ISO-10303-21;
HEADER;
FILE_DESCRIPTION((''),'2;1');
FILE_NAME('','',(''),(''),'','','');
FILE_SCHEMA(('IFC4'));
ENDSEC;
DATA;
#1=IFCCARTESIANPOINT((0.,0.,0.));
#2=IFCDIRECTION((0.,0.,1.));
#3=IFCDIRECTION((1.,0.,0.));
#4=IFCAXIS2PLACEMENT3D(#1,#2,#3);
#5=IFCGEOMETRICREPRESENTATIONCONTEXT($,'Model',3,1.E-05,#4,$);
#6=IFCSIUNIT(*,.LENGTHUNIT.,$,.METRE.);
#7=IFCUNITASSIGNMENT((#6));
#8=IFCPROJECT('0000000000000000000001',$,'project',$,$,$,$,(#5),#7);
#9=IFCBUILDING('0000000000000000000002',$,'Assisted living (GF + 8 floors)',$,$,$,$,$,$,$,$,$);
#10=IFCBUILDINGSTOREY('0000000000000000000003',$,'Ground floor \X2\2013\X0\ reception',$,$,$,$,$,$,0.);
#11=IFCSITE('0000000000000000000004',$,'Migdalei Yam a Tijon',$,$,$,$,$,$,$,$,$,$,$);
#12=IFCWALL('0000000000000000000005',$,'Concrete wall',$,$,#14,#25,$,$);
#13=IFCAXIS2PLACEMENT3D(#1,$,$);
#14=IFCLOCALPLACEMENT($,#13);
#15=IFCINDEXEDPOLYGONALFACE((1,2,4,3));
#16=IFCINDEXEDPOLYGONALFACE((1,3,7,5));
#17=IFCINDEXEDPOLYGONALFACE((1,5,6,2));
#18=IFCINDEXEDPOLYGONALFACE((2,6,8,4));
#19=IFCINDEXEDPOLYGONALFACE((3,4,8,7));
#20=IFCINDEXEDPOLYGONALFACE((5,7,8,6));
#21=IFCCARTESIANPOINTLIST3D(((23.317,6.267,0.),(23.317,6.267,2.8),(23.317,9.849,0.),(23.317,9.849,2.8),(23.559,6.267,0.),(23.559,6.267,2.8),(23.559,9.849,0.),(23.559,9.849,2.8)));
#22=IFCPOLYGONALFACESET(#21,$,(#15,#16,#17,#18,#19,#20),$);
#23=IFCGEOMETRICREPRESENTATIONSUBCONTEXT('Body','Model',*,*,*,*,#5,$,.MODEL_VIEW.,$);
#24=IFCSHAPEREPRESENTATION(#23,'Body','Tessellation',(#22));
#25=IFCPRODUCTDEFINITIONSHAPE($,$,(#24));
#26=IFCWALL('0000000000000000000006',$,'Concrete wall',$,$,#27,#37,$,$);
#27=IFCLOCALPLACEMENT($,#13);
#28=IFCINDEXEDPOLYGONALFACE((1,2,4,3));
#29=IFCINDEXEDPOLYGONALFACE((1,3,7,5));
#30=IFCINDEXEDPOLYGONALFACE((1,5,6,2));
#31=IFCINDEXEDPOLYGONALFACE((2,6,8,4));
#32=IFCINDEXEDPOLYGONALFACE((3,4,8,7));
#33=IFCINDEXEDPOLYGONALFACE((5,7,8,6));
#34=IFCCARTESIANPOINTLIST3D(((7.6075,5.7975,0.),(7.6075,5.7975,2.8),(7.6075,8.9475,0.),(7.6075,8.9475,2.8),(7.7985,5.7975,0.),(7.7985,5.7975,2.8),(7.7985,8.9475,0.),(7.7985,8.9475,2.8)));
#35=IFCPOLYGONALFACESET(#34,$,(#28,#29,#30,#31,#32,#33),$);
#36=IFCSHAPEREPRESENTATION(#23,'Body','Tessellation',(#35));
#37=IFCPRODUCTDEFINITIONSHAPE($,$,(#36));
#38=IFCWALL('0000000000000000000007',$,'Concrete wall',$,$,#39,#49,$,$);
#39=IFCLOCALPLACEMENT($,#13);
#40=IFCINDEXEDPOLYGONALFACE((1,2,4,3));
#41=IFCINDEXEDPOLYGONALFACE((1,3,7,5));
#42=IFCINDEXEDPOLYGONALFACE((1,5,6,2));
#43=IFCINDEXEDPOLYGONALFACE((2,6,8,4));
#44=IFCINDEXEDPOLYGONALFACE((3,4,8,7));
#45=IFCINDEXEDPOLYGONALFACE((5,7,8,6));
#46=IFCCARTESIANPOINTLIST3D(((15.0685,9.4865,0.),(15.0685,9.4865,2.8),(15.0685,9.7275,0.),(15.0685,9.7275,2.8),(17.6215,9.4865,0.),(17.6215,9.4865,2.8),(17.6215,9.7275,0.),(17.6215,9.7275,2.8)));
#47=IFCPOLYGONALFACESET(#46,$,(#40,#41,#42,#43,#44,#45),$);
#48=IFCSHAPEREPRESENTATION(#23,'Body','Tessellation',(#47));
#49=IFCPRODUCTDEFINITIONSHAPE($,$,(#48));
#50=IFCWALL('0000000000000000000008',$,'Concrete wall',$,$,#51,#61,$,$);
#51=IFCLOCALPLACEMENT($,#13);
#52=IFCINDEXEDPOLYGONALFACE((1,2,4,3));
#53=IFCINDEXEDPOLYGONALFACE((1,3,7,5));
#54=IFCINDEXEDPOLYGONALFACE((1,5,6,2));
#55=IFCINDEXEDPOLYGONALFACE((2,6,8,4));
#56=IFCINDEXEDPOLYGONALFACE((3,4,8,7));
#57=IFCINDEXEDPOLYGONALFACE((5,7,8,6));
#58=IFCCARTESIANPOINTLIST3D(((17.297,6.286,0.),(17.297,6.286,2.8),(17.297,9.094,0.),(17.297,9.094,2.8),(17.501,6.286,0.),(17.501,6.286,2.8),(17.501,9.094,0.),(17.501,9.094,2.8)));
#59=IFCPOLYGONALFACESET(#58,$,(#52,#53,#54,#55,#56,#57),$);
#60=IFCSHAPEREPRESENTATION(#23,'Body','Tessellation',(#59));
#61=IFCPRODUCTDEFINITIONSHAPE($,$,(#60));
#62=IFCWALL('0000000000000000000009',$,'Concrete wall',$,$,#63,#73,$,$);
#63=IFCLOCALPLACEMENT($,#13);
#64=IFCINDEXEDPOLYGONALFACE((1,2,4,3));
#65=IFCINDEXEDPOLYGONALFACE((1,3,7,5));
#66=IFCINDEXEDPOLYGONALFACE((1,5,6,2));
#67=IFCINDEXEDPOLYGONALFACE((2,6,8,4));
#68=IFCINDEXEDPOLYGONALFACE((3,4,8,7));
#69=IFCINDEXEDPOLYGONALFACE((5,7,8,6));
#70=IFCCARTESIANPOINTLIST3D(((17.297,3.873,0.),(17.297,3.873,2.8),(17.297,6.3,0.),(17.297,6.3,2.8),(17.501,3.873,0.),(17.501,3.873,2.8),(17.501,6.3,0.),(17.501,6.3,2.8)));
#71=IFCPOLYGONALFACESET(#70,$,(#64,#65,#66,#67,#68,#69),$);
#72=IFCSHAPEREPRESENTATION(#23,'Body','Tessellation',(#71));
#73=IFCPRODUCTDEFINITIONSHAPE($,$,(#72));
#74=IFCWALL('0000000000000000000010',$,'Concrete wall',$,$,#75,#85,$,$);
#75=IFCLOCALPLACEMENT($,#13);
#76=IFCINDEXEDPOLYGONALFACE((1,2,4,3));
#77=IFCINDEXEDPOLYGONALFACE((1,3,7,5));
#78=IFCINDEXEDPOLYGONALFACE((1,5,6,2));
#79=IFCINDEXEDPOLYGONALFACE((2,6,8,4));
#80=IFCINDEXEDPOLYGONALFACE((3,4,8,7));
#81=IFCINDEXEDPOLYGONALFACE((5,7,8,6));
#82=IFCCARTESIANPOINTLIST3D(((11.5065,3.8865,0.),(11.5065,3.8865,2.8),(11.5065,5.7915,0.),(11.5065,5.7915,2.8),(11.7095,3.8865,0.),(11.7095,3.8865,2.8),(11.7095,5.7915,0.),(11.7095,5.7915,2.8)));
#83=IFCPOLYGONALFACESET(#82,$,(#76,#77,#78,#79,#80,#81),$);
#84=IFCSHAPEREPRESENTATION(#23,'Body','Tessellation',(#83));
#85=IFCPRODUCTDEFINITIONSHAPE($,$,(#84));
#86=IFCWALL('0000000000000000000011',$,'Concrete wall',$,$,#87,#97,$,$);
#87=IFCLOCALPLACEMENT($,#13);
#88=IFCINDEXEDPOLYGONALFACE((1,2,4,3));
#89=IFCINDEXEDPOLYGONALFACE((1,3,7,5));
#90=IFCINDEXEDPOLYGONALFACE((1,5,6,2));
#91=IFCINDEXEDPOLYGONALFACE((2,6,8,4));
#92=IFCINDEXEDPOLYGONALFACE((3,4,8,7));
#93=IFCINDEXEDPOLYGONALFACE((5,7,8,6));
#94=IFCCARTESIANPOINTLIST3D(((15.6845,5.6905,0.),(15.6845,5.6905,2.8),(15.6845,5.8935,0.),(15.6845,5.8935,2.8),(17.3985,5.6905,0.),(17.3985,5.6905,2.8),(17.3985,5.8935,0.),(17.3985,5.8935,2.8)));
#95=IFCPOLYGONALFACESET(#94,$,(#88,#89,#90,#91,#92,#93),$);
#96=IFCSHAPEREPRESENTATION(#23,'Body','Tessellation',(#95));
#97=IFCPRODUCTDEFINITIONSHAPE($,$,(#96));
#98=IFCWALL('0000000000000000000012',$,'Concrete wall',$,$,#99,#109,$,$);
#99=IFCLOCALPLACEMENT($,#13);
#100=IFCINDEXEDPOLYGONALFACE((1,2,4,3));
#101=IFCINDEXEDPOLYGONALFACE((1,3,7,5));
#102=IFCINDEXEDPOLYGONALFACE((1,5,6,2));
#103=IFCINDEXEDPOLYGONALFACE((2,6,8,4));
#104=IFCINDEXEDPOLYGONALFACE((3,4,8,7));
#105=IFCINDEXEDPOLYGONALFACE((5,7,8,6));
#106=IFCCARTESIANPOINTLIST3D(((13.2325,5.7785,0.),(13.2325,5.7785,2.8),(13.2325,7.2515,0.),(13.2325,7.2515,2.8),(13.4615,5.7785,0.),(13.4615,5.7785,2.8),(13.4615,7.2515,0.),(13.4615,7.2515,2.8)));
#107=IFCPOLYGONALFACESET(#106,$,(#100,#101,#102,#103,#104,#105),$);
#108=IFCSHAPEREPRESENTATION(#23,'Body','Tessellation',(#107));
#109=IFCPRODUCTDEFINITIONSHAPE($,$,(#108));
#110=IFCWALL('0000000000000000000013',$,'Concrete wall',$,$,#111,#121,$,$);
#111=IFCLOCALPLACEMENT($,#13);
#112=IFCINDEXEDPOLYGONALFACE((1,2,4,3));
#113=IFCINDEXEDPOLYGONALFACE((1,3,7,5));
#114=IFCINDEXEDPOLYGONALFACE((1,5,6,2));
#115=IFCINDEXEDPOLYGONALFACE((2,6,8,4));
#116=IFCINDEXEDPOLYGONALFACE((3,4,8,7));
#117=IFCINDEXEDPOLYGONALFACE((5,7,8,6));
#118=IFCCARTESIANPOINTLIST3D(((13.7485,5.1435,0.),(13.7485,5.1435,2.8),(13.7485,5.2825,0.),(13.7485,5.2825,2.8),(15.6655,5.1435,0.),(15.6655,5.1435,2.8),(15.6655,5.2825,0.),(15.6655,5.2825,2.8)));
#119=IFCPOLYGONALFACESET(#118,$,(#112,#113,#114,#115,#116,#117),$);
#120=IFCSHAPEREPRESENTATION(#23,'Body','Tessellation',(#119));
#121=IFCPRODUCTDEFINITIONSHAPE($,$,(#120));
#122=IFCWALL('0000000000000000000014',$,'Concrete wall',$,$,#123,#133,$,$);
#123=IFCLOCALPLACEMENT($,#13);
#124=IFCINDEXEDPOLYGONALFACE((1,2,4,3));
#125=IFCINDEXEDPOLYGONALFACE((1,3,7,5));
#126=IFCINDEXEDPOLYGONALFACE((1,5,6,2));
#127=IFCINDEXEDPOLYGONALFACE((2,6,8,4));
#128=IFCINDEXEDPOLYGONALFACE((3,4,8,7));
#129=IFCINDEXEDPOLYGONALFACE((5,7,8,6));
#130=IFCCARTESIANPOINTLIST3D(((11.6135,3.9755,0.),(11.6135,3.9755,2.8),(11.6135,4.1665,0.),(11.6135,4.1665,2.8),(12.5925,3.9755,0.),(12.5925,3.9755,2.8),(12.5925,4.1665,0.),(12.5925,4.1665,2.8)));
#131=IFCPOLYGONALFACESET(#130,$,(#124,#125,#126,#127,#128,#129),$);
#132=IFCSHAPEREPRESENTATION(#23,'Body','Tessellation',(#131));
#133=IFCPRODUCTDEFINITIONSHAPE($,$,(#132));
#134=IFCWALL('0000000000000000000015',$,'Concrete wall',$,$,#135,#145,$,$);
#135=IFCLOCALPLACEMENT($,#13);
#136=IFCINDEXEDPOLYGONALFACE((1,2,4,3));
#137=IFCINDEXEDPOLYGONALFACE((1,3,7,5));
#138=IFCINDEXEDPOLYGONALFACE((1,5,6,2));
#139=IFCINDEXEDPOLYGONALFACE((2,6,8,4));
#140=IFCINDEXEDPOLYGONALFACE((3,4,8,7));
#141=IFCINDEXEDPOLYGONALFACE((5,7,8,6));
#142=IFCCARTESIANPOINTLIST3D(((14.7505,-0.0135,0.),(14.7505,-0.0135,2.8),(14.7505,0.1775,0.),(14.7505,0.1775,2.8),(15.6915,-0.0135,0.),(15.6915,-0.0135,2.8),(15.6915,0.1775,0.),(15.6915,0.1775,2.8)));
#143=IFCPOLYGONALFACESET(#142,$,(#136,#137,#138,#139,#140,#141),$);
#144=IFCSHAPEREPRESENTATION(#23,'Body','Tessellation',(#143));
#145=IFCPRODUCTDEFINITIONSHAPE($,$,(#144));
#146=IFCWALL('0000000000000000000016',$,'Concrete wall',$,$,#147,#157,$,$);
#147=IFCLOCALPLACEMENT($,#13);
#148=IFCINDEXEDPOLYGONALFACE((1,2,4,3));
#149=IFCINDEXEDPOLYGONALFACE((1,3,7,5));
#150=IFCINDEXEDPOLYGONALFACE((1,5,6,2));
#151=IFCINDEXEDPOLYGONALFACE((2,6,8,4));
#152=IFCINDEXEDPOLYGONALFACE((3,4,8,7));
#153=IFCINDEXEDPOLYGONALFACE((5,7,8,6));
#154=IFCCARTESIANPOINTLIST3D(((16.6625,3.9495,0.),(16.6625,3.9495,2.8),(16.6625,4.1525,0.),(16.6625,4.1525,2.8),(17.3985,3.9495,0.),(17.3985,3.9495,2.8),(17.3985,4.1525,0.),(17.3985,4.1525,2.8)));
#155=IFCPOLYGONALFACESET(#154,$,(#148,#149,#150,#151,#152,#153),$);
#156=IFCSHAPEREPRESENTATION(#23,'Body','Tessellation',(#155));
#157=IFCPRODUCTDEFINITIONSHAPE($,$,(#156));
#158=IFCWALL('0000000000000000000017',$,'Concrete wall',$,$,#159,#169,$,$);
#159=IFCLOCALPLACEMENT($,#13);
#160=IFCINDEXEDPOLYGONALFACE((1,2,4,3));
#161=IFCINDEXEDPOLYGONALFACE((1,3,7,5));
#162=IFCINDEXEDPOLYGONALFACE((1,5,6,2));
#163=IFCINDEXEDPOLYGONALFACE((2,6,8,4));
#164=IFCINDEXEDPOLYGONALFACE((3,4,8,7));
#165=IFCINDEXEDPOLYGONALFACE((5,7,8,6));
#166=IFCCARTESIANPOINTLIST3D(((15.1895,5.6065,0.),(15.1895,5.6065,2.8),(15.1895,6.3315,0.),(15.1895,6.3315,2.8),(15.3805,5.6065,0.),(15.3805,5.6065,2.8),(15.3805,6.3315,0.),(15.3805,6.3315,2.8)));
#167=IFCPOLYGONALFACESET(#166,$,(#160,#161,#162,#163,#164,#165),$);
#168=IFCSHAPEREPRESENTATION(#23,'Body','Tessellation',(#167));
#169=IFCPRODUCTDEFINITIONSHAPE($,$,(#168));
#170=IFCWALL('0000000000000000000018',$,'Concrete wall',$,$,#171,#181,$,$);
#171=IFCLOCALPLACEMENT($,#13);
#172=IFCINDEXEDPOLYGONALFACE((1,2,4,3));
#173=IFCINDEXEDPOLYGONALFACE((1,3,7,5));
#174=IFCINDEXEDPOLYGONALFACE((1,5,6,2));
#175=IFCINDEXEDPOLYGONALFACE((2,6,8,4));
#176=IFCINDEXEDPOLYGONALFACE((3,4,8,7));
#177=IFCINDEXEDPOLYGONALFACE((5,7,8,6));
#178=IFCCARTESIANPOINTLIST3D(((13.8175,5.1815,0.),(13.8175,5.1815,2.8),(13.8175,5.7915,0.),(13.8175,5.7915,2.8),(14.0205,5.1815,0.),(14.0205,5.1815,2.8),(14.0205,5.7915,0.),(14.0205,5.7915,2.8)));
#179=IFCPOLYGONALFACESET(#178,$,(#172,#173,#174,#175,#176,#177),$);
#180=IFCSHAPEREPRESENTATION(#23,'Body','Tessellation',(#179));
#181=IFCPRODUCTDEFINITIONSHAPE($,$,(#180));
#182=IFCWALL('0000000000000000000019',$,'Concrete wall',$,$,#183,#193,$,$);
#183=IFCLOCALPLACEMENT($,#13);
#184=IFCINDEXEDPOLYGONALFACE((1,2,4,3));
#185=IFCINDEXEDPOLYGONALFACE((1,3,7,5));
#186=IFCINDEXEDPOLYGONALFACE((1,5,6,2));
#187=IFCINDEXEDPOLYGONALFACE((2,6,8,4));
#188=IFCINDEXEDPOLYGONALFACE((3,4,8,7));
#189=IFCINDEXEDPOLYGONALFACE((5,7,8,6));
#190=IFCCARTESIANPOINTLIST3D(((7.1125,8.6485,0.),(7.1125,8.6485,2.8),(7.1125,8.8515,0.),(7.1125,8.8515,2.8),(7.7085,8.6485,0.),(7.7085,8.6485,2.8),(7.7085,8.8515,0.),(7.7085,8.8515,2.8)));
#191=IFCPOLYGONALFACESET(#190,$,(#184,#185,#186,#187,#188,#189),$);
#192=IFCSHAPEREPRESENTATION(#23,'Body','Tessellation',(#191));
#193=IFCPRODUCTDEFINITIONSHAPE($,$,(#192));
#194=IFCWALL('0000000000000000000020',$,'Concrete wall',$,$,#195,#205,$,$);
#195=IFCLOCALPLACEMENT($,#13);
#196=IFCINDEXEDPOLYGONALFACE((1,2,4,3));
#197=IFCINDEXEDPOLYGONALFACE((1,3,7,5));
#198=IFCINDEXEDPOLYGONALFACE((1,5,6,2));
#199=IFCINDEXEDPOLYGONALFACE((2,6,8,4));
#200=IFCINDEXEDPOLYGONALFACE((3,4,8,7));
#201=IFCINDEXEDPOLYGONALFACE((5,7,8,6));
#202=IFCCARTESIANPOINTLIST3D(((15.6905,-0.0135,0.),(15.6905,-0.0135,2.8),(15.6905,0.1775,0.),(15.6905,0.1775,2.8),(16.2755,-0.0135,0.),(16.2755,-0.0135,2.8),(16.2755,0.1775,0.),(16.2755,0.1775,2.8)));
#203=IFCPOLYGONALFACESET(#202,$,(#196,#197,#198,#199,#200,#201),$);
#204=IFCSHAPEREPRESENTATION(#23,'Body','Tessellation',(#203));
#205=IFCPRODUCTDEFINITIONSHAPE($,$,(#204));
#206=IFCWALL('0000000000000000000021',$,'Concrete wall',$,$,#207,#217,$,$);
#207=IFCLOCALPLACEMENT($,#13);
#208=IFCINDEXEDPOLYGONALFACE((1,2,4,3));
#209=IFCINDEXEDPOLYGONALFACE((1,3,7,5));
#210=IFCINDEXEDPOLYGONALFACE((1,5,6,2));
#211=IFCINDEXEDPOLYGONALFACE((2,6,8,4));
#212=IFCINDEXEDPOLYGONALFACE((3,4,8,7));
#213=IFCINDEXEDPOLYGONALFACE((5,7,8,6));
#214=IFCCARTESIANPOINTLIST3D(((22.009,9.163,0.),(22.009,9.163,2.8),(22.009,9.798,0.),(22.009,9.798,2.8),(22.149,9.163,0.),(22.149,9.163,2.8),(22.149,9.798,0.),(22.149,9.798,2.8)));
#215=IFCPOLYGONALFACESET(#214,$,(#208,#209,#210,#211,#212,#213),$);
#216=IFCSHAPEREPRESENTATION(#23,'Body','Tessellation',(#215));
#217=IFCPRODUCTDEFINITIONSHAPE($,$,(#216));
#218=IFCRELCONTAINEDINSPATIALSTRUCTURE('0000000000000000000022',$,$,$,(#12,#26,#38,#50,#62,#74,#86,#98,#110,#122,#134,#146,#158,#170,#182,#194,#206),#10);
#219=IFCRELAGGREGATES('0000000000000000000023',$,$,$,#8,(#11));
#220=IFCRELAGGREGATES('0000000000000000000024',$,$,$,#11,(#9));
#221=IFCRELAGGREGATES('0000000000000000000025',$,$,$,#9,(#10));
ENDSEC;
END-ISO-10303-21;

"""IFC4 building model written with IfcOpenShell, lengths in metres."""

from ifc_helpers import new_model, si_unit, frame, origin_with_axes, context, subcontext, project, spatial, line, indexed_curve, outline, extrude, element, save


model = new_model("IFC4")

# Units and contexts
model_context = context("Model", 3, precision=1e-05, world=origin_with_axes())
body_context = subcontext(model_context, "Body", "Model", "MODEL_VIEW")
ifc_project = project(units=[si_unit("LENGTHUNIT", "METRE")], contexts=[model_context])

# Site, building, storey
site = spatial("IfcSite", under=ifc_project, Name="Migdalei Yam a Tijon")
building = spatial("IfcBuilding", under=site, Name="Assisted living (GF + 8 floors)")
storey = spatial("IfcBuildingStorey", under=building, Name="Ground floor – reception", Elevation=0.0)

# Walls
element("IfcWall", 1, inside=storey, Name="Concrete wall", context=body_context, shape_type="SweptSolid", body=[
    extrude(outline(indexed_curve([(0.0, 0.0), (0.242, 0.0), (0.242, 3.582), (0.0, 3.582)], segments=[line(1, 2, 3, 4, 1)])), frame((23.317, 6.267, 0.0), z_axis=(0.0, 0.0, 1.0), x_axis=(1.0, 0.0, 0.0)), (0.0, 0.0, 1.0), 2.8),
])
element("IfcWall", 2, inside=storey, Name="Concrete wall", context=body_context, shape_type="SweptSolid", body=[
    extrude(outline(indexed_curve([(0.0, 0.0), (0.191, 0.0), (0.191, 3.15), (0.0, 3.15)], segments=[line(1, 2, 3, 4, 1)])), frame((7.6075, 5.7975, 0.0), z_axis=(0.0, 0.0, 1.0), x_axis=(1.0, 0.0, 0.0)), (0.0, 0.0, 1.0), 2.8),
])
element("IfcWall", 3, inside=storey, Name="Concrete wall", context=body_context, shape_type="SweptSolid", body=[
    extrude(outline(indexed_curve([(0.0, 0.0), (2.553, 0.0), (2.553, 0.241), (0.0, 0.241)], segments=[line(1, 2, 3, 4, 1)])), frame((15.0685, 9.4865, 0.0), z_axis=(0.0, 0.0, 1.0), x_axis=(1.0, 0.0, 0.0)), (0.0, 0.0, 1.0), 2.8),
])
element("IfcWall", 4, inside=storey, Name="Concrete wall", context=body_context, shape_type="SweptSolid", body=[
    extrude(outline(indexed_curve([(0.0, 0.0), (0.204, 0.0), (0.204, 2.808), (0.0, 2.808)], segments=[line(1, 2, 3, 4, 1)])), frame((17.297, 6.286, 0.0), z_axis=(0.0, 0.0, 1.0), x_axis=(1.0, 0.0, 0.0)), (0.0, 0.0, 1.0), 2.8),
])
element("IfcWall", 5, inside=storey, Name="Concrete wall", context=body_context, shape_type="SweptSolid", body=[
    extrude(outline(indexed_curve([(0.0, 0.0), (0.204, 0.0), (0.204, 2.427), (0.0, 2.427)], segments=[line(1, 2, 3, 4, 1)])), frame((17.297, 3.873, 0.0), z_axis=(0.0, 0.0, 1.0), x_axis=(1.0, 0.0, 0.0)), (0.0, 0.0, 1.0), 2.8),
])
element("IfcWall", 6, inside=storey, Name="Concrete wall", context=body_context, shape_type="SweptSolid", body=[
    extrude(outline(indexed_curve([(0.0, 0.0), (0.203, 0.0), (0.203, 1.905), (0.0, 1.905)], segments=[line(1, 2, 3, 4, 1)])), frame((11.5065, 3.8865, 0.0), z_axis=(0.0, 0.0, 1.0), x_axis=(1.0, 0.0, 0.0)), (0.0, 0.0, 1.0), 2.8),
])
element("IfcWall", 7, inside=storey, Name="Concrete wall", context=body_context, shape_type="SweptSolid", body=[
    extrude(outline(indexed_curve([(0.0, 0.0), (1.714, 0.0), (1.714, 0.203), (0.0, 0.203)], segments=[line(1, 2, 3, 4, 1)])), frame((15.6845, 5.6905, 0.0), z_axis=(0.0, 0.0, 1.0), x_axis=(1.0, 0.0, 0.0)), (0.0, 0.0, 1.0), 2.8),
])
element("IfcWall", 8, inside=storey, Name="Concrete wall", context=body_context, shape_type="SweptSolid", body=[
    extrude(outline(indexed_curve([(0.0, 0.0), (0.229, 0.0), (0.229, 1.473), (0.0, 1.473)], segments=[line(1, 2, 3, 4, 1)])), frame((13.2325, 5.7785, 0.0), z_axis=(0.0, 0.0, 1.0), x_axis=(1.0, 0.0, 0.0)), (0.0, 0.0, 1.0), 2.8),
])
element("IfcWall", 9, inside=storey, Name="Concrete wall", context=body_context, shape_type="SweptSolid", body=[
    extrude(outline(indexed_curve([(0.0, 0.0), (1.917, 0.0), (1.917, 0.139), (0.0, 0.139)], segments=[line(1, 2, 3, 4, 1)])), frame((13.7485, 5.1435, 0.0), z_axis=(0.0, 0.0, 1.0), x_axis=(1.0, 0.0, 0.0)), (0.0, 0.0, 1.0), 2.8),
])
element("IfcWall", 10, inside=storey, Name="Concrete wall", context=body_context, shape_type="SweptSolid", body=[
    extrude(outline(indexed_curve([(0.0, 0.0), (0.979, 0.0), (0.979, 0.191), (0.0, 0.191)], segments=[line(1, 2, 3, 4, 1)])), frame((11.6135, 3.9755, 0.0), z_axis=(0.0, 0.0, 1.0), x_axis=(1.0, 0.0, 0.0)), (0.0, 0.0, 1.0), 2.8),
])
element("IfcWall", 11, inside=storey, Name="Concrete wall", context=body_context, shape_type="SweptSolid", body=[
    extrude(outline(indexed_curve([(0.0, 0.0), (0.941, 0.0), (0.941, 0.191), (0.0, 0.191)], segments=[line(1, 2, 3, 4, 1)])), frame((14.7505, -0.0135, 0.0), z_axis=(0.0, 0.0, 1.0), x_axis=(1.0, 0.0, 0.0)), (0.0, 0.0, 1.0), 2.8),
])
element("IfcWall", 12, inside=storey, Name="Concrete wall", context=body_context, shape_type="SweptSolid", body=[
    extrude(outline(indexed_curve([(0.0, 0.0), (0.736, 0.0), (0.736, 0.203), (0.0, 0.203)], segments=[line(1, 2, 3, 4, 1)])), frame((16.6625, 3.9495, 0.0), z_axis=(0.0, 0.0, 1.0), x_axis=(1.0, 0.0, 0.0)), (0.0, 0.0, 1.0), 2.8),
])
element("IfcWall", 13, inside=storey, Name="Concrete wall", context=body_context, shape_type="SweptSolid", body=[
    extrude(outline(indexed_curve([(0.0, 0.0), (0.191, 0.0), (0.191, 0.725), (0.0, 0.725)], segments=[line(1, 2, 3, 4, 1)])), frame((15.1895, 5.6065, 0.0), z_axis=(0.0, 0.0, 1.0), x_axis=(1.0, 0.0, 0.0)), (0.0, 0.0, 1.0), 2.8),
])
element("IfcWall", 14, inside=storey, Name="Concrete wall", context=body_context, shape_type="SweptSolid", body=[
    extrude(outline(indexed_curve([(0.0, 0.0), (0.203, 0.0), (0.203, 0.61), (0.0, 0.61)], segments=[line(1, 2, 3, 4, 1)])), frame((13.8175, 5.1815, 0.0), z_axis=(0.0, 0.0, 1.0), x_axis=(1.0, 0.0, 0.0)), (0.0, 0.0, 1.0), 2.8),
])
element("IfcWall", 15, inside=storey, Name="Concrete wall", context=body_context, shape_type="SweptSolid", body=[
    extrude(outline(indexed_curve([(0.0, 0.0), (0.596, 0.0), (0.596, 0.203), (0.0, 0.203)], segments=[line(1, 2, 3, 4, 1)])), frame((7.1125, 8.6485, 0.0), z_axis=(0.0, 0.0, 1.0), x_axis=(1.0, 0.0, 0.0)), (0.0, 0.0, 1.0), 2.8),
])
element("IfcWall", 16, inside=storey, Name="Concrete wall", context=body_context, shape_type="SweptSolid", body=[
    extrude(outline(indexed_curve([(0.0, 0.0), (0.585, 0.0), (0.585, 0.191), (0.0, 0.191)], segments=[line(1, 2, 3, 4, 1)])), frame((15.6905, -0.0135, 0.0), z_axis=(0.0, 0.0, 1.0), x_axis=(1.0, 0.0, 0.0)), (0.0, 0.0, 1.0), 2.8),
])
element("IfcWall", 17, inside=storey, Name="Concrete wall", context=body_context, shape_type="SweptSolid", body=[
    extrude(outline(indexed_curve([(0.0, 0.0), (0.14, 0.0), (0.14, 0.635), (0.0, 0.635)], segments=[line(1, 2, 3, 4, 1)])), frame((22.009, 9.163, 0.0), z_axis=(0.0, 0.0, 1.0), x_axis=(1.0, 0.0, 0.0)), (0.0, 0.0, 1.0), 2.8),
])

save(model, "model.ifc")
